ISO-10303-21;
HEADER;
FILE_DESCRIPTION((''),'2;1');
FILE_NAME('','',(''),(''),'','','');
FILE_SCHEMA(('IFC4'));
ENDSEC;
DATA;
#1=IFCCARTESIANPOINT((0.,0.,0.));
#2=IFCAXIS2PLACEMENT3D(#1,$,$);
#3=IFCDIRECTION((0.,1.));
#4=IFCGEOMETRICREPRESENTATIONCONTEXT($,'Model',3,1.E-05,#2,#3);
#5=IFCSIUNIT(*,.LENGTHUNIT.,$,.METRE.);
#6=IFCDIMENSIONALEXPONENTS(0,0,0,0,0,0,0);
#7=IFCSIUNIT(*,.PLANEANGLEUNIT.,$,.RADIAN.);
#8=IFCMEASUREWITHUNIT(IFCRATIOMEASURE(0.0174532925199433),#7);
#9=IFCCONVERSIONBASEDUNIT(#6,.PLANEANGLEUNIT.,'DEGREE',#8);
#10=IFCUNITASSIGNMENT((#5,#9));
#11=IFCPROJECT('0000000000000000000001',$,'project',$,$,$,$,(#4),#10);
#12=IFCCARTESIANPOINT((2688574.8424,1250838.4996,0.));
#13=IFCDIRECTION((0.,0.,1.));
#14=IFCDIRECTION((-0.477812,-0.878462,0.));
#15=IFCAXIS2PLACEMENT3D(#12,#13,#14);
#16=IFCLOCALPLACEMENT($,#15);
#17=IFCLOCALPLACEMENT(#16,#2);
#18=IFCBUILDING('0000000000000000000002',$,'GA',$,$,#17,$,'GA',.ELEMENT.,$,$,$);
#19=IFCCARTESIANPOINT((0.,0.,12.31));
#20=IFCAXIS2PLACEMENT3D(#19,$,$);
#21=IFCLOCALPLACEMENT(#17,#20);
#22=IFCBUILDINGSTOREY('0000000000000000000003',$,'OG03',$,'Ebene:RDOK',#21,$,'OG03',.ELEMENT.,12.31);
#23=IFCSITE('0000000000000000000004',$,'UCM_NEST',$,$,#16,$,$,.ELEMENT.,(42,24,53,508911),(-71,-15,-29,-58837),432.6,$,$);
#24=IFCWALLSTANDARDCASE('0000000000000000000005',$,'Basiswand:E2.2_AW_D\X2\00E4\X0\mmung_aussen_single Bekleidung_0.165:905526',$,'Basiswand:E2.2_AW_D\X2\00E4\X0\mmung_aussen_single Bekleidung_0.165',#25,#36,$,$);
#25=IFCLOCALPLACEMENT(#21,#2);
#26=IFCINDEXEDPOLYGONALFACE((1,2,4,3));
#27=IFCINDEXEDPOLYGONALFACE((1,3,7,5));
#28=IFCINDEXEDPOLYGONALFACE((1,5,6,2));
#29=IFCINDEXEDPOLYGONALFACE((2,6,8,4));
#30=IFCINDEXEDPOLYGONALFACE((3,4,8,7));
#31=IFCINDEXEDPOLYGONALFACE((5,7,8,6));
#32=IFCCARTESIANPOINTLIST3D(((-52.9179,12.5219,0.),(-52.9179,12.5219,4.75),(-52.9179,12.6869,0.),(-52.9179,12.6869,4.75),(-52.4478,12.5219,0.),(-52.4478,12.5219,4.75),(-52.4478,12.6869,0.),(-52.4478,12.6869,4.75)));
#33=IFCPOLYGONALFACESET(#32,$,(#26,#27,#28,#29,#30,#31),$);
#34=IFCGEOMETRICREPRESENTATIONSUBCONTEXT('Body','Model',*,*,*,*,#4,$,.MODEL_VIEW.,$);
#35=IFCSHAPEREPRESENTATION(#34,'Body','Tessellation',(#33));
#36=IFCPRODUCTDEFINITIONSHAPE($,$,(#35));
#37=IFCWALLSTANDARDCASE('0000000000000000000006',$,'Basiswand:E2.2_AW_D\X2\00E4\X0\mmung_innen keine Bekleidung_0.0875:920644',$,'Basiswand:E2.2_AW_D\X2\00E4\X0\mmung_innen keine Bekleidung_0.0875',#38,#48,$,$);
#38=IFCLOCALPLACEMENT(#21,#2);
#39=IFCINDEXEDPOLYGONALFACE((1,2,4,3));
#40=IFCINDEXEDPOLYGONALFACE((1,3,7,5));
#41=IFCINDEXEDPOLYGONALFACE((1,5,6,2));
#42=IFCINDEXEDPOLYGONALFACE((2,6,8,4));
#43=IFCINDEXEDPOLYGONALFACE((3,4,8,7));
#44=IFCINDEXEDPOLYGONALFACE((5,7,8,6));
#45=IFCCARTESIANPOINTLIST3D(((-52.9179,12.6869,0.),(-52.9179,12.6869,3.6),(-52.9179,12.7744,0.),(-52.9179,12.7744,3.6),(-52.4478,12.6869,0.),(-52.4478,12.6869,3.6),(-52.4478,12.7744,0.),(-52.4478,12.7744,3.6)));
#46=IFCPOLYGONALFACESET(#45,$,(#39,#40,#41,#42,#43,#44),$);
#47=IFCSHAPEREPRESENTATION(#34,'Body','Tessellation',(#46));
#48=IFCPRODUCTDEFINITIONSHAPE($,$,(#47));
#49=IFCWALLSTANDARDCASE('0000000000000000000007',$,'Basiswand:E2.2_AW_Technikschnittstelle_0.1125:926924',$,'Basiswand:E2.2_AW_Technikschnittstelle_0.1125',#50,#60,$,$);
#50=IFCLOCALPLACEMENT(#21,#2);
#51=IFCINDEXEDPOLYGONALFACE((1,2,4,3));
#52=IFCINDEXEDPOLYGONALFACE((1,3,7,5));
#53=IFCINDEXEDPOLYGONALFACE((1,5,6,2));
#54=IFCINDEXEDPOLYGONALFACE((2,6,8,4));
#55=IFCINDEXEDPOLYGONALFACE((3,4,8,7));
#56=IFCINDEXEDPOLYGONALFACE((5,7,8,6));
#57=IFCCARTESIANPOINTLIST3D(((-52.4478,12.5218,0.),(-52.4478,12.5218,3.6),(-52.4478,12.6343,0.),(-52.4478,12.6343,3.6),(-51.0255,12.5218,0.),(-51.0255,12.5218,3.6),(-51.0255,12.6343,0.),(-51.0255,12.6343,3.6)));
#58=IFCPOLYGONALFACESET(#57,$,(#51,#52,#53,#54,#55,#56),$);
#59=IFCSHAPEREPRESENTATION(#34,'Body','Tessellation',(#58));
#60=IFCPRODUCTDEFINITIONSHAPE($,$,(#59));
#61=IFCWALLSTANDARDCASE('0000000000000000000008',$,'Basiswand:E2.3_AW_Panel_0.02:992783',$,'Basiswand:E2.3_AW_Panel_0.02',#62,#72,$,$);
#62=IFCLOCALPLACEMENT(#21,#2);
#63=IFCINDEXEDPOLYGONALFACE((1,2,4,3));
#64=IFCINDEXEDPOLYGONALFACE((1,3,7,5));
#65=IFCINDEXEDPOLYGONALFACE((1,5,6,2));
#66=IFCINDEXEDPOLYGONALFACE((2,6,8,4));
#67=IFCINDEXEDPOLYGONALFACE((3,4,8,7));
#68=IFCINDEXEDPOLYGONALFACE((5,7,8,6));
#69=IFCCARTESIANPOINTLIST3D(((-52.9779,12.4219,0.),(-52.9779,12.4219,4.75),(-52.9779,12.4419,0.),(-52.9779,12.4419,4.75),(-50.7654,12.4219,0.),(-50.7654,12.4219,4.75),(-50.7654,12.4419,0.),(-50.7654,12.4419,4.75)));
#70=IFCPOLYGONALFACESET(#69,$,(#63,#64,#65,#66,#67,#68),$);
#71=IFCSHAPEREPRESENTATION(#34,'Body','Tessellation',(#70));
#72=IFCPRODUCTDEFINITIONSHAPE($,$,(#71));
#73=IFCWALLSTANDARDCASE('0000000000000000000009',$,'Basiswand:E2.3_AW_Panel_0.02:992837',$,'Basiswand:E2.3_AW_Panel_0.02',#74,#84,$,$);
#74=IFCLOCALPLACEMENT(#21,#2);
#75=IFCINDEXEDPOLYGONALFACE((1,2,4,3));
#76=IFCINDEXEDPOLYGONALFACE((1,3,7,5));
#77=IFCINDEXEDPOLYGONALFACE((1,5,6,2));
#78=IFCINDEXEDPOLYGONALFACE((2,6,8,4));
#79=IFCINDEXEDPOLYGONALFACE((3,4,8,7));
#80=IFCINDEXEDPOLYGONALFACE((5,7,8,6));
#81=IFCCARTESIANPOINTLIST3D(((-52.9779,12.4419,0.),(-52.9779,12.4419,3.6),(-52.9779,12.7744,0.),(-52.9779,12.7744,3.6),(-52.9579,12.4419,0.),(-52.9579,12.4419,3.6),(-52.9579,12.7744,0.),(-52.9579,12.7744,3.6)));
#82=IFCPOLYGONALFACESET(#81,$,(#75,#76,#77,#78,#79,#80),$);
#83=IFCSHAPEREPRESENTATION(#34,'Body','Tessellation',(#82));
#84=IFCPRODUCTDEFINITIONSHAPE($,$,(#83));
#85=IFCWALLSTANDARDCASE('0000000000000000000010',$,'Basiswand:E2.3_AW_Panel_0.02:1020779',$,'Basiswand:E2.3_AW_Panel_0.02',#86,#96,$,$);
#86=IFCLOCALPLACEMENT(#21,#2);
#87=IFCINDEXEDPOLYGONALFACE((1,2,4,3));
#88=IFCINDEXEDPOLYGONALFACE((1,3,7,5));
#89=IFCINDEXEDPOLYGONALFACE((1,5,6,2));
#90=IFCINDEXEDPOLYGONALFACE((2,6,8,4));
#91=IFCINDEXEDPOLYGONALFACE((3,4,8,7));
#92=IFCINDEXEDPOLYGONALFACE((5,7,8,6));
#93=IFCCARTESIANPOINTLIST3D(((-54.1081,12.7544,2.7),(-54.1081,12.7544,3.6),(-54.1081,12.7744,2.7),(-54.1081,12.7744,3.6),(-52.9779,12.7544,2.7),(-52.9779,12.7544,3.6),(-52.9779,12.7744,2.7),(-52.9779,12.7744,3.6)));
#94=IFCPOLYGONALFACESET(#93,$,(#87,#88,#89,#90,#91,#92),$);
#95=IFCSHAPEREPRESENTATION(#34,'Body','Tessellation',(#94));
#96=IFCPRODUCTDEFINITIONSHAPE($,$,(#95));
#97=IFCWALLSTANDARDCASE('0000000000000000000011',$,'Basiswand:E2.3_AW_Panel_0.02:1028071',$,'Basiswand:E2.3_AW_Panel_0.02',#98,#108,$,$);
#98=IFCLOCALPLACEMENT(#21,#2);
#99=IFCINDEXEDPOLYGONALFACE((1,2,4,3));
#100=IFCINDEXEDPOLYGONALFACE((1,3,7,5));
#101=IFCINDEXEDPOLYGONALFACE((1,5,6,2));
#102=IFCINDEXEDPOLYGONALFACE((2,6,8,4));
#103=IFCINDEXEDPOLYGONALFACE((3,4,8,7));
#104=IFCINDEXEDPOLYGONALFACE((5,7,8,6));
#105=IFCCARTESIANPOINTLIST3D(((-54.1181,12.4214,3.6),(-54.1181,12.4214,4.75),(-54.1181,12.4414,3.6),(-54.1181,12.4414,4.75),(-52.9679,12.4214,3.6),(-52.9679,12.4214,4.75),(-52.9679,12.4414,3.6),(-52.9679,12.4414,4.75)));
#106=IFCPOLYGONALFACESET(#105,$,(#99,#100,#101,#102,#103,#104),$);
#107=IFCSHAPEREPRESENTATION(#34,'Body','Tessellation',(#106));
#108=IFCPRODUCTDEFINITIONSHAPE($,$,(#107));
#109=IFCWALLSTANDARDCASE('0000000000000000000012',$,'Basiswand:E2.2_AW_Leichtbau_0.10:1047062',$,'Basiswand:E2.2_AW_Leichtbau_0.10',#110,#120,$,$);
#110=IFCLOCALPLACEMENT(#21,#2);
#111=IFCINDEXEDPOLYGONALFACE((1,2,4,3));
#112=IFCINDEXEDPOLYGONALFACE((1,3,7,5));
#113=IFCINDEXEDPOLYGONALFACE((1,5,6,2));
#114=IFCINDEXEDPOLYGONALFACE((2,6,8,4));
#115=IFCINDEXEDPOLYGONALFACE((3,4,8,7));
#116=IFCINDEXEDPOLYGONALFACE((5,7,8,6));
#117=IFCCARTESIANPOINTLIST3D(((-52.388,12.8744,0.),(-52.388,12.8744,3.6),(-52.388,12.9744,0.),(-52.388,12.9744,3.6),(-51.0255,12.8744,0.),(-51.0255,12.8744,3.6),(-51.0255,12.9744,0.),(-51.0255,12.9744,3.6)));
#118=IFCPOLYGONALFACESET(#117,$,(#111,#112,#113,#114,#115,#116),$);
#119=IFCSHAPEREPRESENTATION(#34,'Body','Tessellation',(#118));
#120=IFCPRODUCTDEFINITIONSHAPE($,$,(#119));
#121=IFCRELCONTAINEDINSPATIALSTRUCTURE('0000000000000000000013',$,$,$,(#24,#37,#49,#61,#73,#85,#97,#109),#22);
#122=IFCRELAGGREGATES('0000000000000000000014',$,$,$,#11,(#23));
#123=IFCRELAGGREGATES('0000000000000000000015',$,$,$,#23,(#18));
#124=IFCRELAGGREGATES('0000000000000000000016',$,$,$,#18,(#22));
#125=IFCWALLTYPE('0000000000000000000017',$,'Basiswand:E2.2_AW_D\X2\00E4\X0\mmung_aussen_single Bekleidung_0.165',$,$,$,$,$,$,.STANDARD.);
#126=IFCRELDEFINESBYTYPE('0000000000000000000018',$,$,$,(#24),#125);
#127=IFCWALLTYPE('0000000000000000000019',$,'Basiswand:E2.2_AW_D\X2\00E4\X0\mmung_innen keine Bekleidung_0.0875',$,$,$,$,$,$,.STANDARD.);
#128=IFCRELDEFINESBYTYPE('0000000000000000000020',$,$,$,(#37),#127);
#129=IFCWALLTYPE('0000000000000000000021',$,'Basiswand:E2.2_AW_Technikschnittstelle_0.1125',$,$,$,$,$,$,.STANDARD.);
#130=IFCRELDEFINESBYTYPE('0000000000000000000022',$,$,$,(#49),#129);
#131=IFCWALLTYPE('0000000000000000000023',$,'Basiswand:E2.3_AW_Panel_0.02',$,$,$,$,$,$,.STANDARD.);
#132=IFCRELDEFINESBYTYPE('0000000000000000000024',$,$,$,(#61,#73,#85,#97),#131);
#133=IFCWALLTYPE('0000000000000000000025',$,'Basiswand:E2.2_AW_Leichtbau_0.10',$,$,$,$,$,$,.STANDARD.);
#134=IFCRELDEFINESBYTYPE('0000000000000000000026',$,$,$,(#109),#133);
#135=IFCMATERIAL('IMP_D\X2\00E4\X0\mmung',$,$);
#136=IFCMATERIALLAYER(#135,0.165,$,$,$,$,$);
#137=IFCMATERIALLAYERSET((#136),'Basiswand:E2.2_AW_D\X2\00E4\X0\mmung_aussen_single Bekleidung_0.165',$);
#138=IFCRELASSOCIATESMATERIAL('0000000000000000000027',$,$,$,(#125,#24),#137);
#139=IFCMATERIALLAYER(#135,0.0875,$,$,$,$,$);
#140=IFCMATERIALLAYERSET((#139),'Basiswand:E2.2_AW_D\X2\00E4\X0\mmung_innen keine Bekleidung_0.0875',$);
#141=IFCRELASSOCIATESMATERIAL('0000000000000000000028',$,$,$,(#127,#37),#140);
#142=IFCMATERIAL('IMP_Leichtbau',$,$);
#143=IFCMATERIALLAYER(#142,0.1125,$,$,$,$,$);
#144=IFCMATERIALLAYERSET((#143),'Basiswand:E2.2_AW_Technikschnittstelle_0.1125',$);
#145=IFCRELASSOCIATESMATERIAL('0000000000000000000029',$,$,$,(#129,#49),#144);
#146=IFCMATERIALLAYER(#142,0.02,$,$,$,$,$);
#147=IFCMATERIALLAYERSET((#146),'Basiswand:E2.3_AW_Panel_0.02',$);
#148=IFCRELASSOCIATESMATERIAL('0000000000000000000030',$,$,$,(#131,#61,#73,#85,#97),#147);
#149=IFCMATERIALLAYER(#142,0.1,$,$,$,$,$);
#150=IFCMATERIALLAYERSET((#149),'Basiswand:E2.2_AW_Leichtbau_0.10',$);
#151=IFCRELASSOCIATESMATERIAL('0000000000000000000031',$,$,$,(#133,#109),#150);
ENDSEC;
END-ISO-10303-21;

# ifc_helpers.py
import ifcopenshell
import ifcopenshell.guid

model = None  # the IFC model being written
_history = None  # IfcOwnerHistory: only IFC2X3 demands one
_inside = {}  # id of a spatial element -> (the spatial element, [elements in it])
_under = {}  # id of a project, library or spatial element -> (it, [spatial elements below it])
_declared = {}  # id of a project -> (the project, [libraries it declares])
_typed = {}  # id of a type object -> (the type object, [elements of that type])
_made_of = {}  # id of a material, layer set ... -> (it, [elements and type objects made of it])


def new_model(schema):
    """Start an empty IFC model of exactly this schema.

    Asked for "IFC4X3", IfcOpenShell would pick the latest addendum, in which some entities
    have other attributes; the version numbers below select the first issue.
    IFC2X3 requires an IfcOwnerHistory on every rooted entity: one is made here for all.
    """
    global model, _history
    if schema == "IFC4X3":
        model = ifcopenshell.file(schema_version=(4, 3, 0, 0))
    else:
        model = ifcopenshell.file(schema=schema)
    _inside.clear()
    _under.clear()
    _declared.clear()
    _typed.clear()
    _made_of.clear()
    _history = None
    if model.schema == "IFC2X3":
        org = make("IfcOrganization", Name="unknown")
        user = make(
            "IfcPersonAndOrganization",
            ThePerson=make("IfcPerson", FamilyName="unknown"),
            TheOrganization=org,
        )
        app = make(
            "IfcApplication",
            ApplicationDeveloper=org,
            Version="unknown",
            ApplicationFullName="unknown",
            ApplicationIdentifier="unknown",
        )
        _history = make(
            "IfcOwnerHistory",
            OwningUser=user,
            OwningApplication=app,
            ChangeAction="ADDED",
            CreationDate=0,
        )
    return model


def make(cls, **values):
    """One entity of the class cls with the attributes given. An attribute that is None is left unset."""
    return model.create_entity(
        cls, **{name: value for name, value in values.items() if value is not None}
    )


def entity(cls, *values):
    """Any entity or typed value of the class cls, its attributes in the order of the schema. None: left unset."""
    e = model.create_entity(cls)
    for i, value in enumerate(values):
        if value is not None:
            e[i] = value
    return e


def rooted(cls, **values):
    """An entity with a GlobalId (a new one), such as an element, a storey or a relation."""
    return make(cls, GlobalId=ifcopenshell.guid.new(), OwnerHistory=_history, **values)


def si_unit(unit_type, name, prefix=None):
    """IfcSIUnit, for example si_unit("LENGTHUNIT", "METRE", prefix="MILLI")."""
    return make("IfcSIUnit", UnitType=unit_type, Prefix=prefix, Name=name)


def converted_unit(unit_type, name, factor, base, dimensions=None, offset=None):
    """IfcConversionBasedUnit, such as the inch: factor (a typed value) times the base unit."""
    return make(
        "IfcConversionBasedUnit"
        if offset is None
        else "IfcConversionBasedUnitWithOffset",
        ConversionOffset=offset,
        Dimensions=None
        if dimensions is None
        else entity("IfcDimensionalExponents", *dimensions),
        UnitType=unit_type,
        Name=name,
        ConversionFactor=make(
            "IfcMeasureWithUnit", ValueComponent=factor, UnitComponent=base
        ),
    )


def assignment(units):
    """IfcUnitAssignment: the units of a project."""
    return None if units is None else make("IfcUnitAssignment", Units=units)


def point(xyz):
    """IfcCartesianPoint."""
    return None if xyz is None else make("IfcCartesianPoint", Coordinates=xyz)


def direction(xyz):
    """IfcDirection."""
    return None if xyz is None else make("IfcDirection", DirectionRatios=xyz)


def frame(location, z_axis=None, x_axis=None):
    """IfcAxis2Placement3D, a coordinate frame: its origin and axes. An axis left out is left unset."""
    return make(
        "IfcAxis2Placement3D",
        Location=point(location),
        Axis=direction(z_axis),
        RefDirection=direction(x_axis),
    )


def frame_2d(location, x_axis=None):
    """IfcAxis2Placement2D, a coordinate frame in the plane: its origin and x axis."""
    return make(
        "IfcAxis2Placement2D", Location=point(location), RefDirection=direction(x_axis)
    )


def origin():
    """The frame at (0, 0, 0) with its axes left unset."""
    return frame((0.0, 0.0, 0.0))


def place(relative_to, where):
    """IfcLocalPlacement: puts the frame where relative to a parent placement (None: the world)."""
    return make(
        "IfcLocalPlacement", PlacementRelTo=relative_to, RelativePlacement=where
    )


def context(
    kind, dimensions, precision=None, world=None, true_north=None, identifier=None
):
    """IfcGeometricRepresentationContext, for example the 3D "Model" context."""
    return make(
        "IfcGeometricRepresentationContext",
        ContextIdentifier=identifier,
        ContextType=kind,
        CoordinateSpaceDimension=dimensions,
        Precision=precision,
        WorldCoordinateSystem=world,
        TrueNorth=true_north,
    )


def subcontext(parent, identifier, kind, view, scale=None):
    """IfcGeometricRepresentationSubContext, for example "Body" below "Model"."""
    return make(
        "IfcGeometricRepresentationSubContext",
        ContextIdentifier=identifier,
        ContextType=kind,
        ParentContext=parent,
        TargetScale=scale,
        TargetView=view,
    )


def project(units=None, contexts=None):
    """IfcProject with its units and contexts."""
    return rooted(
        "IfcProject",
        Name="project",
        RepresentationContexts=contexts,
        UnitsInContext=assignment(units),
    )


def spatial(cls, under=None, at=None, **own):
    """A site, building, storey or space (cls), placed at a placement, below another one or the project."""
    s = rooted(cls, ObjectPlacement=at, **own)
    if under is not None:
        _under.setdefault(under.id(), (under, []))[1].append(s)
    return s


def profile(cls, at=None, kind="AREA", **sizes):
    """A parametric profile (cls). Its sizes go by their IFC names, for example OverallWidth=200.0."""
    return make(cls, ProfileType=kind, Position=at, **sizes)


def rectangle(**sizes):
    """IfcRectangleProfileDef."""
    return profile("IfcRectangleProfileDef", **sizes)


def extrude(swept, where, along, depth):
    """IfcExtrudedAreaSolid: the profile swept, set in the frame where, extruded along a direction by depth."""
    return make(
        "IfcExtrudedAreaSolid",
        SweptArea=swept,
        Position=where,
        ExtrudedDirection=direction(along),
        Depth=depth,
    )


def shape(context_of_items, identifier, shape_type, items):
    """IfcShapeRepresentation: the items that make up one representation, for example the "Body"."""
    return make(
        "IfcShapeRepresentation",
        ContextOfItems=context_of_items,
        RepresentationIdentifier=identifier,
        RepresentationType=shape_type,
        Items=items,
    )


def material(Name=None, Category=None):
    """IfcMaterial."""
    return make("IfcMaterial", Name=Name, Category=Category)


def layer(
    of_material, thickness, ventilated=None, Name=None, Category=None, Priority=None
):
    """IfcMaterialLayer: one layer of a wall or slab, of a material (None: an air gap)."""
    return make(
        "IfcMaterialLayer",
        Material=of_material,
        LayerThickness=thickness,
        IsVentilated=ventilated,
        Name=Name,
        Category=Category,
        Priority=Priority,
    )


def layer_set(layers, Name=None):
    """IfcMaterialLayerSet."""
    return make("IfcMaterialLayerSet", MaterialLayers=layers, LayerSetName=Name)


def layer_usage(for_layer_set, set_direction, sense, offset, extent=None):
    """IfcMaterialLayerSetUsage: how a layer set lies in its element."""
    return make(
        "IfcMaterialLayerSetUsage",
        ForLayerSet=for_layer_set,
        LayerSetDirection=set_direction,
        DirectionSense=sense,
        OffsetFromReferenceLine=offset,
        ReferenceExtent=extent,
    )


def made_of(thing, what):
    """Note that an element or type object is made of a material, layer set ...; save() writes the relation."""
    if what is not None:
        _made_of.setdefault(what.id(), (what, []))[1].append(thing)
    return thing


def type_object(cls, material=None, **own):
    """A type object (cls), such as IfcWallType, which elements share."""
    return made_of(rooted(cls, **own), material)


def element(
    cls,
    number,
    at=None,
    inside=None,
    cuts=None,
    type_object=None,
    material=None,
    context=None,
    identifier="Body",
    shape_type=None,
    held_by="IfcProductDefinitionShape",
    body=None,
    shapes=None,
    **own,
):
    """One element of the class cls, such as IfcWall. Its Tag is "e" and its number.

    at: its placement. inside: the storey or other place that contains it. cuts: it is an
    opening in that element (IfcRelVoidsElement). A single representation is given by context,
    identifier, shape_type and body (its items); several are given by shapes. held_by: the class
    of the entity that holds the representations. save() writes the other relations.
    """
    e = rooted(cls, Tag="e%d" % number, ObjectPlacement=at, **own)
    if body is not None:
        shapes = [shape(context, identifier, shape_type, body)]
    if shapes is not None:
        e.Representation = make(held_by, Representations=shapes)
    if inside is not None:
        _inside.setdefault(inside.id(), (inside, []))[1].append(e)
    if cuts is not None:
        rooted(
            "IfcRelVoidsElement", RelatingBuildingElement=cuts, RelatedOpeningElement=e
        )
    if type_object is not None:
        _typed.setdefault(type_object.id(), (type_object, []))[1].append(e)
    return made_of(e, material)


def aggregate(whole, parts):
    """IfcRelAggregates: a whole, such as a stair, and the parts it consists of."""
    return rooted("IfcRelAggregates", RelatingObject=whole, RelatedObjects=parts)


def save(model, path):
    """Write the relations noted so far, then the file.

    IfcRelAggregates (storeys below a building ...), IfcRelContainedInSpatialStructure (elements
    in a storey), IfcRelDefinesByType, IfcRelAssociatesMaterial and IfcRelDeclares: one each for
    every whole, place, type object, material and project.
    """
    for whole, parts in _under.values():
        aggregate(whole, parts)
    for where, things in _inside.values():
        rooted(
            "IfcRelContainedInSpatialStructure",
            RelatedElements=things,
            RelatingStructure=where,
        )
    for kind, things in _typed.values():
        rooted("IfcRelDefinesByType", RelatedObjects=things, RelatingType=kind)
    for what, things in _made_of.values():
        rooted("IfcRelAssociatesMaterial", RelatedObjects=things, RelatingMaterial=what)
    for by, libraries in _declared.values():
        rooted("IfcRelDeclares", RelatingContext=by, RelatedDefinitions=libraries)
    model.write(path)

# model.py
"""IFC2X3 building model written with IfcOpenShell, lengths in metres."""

from ifc_helpers import new_model, entity, si_unit, converted_unit, direction, frame, frame_2d, origin, place, context, subcontext, project, spatial, rectangle, extrude, material, layer, layer_set, layer_usage, type_object, element, save


model = new_model("IFC2X3")

# Units and contexts
model_context = context("Model", 3, precision=1e-05, world=origin(), true_north=direction((0.0, 1.0)))
body_context = subcontext(model_context, "Body", "Model", "MODEL_VIEW")
ifc_project = project(units=[si_unit("LENGTHUNIT", "METRE"), converted_unit("PLANEANGLEUNIT", "DEGREE", entity("IfcRatioMeasure", 0.0174532925199433), si_unit("PLANEANGLEUNIT", "RADIAN"), dimensions=[0, 0, 0, 0, 0, 0, 0])], contexts=[model_context])

# Site, building, storey
site_placement = place(None, frame((2688574.8424, 1250838.4996, 0.0), z_axis=(0.0, 0.0, 1.0), x_axis=(-0.477812, -0.878462, 0.0)))
site = spatial("IfcSite", under=ifc_project, at=site_placement, Name="UCM_NEST", CompositionType="ELEMENT", RefLatitude=(42, 24, 53, 508911), RefLongitude=(-71, -15, -29, -58837), RefElevation=432.6)
building_placement = place(site_placement, origin())
building = spatial("IfcBuilding", under=site, at=building_placement, Name="GA", LongName="GA", CompositionType="ELEMENT")
storey_placement = place(building_placement, frame((0.0, 0.0, 12.31)))
storey = spatial("IfcBuildingStorey", under=building, at=storey_placement, Name="OG03", ObjectType="Ebene:RDOK", LongName="OG03", CompositionType="ELEMENT", Elevation=12.31)

# Shared definitions
ifc_material_1 = material(Name="IMP_Dämmung")

# Wall
ifc_layer_1 = layer(ifc_material_1, 0.165)
ifc_layer_set_1 = layer_set([ifc_layer_1], Name="Basiswand:E2.2_AW_Dämmung_aussen_single Bekleidung_0.165")
ifc_layer_usage_1 = layer_usage(ifc_layer_set_1, "AXIS2", "NEGATIVE", 0.0825)
wall_type_1 = type_object("IfcWallType", Name="Basiswand:E2.2_AW_Dämmung_aussen_single Bekleidung_0.165", PredefinedType="STANDARD", material=ifc_layer_set_1)
wall_1_placement = place(storey_placement, frame((-52.4478, 12.6044, 0.0), z_axis=(0.0, 0.0, 1.0), x_axis=(-1.0, 0.0, 0.0)))
element("IfcWallStandardCase", 1, at=wall_1_placement, inside=storey, type_object=wall_type_1, material=ifc_layer_usage_1, Name="Basiswand:E2.2_AW_Dämmung_aussen_single Bekleidung_0.165:905526", ObjectType="Basiswand:E2.2_AW_Dämmung_aussen_single Bekleidung_0.165", context=body_context, shape_type="SweptSolid", body=[
    extrude(rectangle(XDim=0.4701, YDim=0.165, at=frame_2d((0.235, 0.0), x_axis=(-1.0, 0.0))), origin(), (0.0, 0.0, 1.0), 4.75),
])

# Walls
ifc_layer_2 = layer(ifc_material_1, 0.0875)
ifc_layer_set_2 = layer_set([ifc_layer_2], Name="Basiswand:E2.2_AW_Dämmung_innen keine Bekleidung_0.0875")
ifc_layer_usage_2 = layer_usage(ifc_layer_set_2, "AXIS2", "NEGATIVE", 0.0437)
wall_type_2 = type_object("IfcWallType", Name="Basiswand:E2.2_AW_Dämmung_innen keine Bekleidung_0.0875", PredefinedType="STANDARD", material=ifc_layer_set_2)
wall_2_placement = place(storey_placement, frame((-52.4478, 12.7307, 0.0), z_axis=(0.0, 0.0, 1.0), x_axis=(-1.0, 0.0, 0.0)))
element("IfcWallStandardCase", 2, at=wall_2_placement, inside=storey, type_object=wall_type_2, material=ifc_layer_usage_2, Name="Basiswand:E2.2_AW_Dämmung_innen keine Bekleidung_0.0875:920644", ObjectType="Basiswand:E2.2_AW_Dämmung_innen keine Bekleidung_0.0875", context=body_context, shape_type="SweptSolid", body=[
    extrude(rectangle(XDim=0.4701, YDim=0.0875, at=frame_2d((0.235, 0.0), x_axis=(-1.0, 0.0))), origin(), (0.0, 0.0, 1.0), 3.6),
])
ifc_material_2 = material(Name="IMP_Leichtbau")
ifc_layer_3 = layer(ifc_material_2, 0.1125)
ifc_layer_set_3 = layer_set([ifc_layer_3], Name="Basiswand:E2.2_AW_Technikschnittstelle_0.1125")
ifc_layer_usage_3 = layer_usage(ifc_layer_set_3, "AXIS2", "NEGATIVE", 0.0563)
wall_type_3 = type_object("IfcWallType", Name="Basiswand:E2.2_AW_Technikschnittstelle_0.1125", PredefinedType="STANDARD", material=ifc_layer_set_3)
wall_3_placement = place(storey_placement, frame((-52.4478, 12.578, 0.0)))
element("IfcWallStandardCase", 3, at=wall_3_placement, inside=storey, type_object=wall_type_3, material=ifc_layer_usage_3, Name="Basiswand:E2.2_AW_Technikschnittstelle_0.1125:926924", ObjectType="Basiswand:E2.2_AW_Technikschnittstelle_0.1125", context=body_context, shape_type="SweptSolid", body=[
    extrude(rectangle(XDim=1.4223, YDim=0.1125, at=frame_2d((0.7112, 0.0), x_axis=(-1.0, 0.0))), origin(), (0.0, 0.0, 1.0), 3.6),
])
ifc_layer_4 = layer(ifc_material_2, 0.02)
ifc_layer_set_4 = layer_set([ifc_layer_4], Name="Basiswand:E2.3_AW_Panel_0.02")
ifc_layer_usage_4 = layer_usage(ifc_layer_set_4, "AXIS2", "NEGATIVE", 0.01)
wall_type_4 = type_object("IfcWallType", Name="Basiswand:E2.3_AW_Panel_0.02", PredefinedType="STANDARD", material=ifc_layer_set_4)
wall_4_placement = place(storey_placement, frame((-50.7654, 12.4319, 0.0), z_axis=(0.0, 0.0, 1.0), x_axis=(-1.0, 0.0, 0.0)))
element("IfcWallStandardCase", 4, at=wall_4_placement, inside=storey, type_object=wall_type_4, material=ifc_layer_usage_4, Name="Basiswand:E2.3_AW_Panel_0.02:992783", ObjectType="Basiswand:E2.3_AW_Panel_0.02", context=body_context, shape_type="SweptSolid", body=[
    extrude(rectangle(XDim=2.2124, YDim=0.02, at=frame_2d((1.1062, 0.0), x_axis=(-1.0, 0.0))), origin(), (0.0, 0.0, 1.0), 4.75),
])
ifc_layer_usage_5 = layer_usage(ifc_layer_set_4, "AXIS2", "NEGATIVE", 0.01)
wall_5_placement = place(storey_placement, frame((-52.9679, 12.7744, 0.0), z_axis=(0.0, 0.0, 1.0), x_axis=(0.0, -1.0, 0.0)))
element("IfcWallStandardCase", 5, at=wall_5_placement, inside=storey, type_object=wall_type_4, material=ifc_layer_usage_5, Name="Basiswand:E2.3_AW_Panel_0.02:992837", ObjectType="Basiswand:E2.3_AW_Panel_0.02", context=body_context, shape_type="SweptSolid", body=[
    extrude(rectangle(XDim=0.3325, YDim=0.02, at=frame_2d((0.1663, 0.0), x_axis=(-1.0, 0.0))), origin(), (0.0, 0.0, 1.0), 3.6),
])
ifc_layer_usage_6 = layer_usage(ifc_layer_set_4, "AXIS2", "NEGATIVE", 0.01)
wall_6_placement = place(storey_placement, frame((-52.9779, 12.7644, 2.7), z_axis=(0.0, 0.0, 1.0), x_axis=(-1.0, 0.0, 0.0)))
element("IfcWallStandardCase", 6, at=wall_6_placement, inside=storey, type_object=wall_type_4, material=ifc_layer_usage_6, Name="Basiswand:E2.3_AW_Panel_0.02:1020779", ObjectType="Basiswand:E2.3_AW_Panel_0.02", context=body_context, shape_type="SweptSolid", body=[
    extrude(rectangle(XDim=1.1302, YDim=0.02, at=frame_2d((0.5651, 0.0), x_axis=(-1.0, 0.0))), origin(), (0.0, 0.0, 1.0), 0.9),
])
ifc_layer_usage_7 = layer_usage(ifc_layer_set_4, "AXIS2", "NEGATIVE", 0.01)
wall_7_placement = place(storey_placement, frame((-54.1181, 12.4314, 3.6)))
element("IfcWallStandardCase", 7, at=wall_7_placement, inside=storey, type_object=wall_type_4, material=ifc_layer_usage_7, Name="Basiswand:E2.3_AW_Panel_0.02:1028071", ObjectType="Basiswand:E2.3_AW_Panel_0.02", context=body_context, shape_type="SweptSolid", body=[
    extrude(rectangle(XDim=1.1502, YDim=0.02, at=frame_2d((0.5751, 0.0), x_axis=(-1.0, 0.0))), origin(), (0.0, 0.0, 1.0), 1.15),
])
ifc_layer_5 = layer(ifc_material_2, 0.1)
ifc_layer_set_5 = layer_set([ifc_layer_5], Name="Basiswand:E2.2_AW_Leichtbau_0.10")
ifc_layer_usage_8 = layer_usage(ifc_layer_set_5, "AXIS2", "NEGATIVE", 0.05)
wall_type_5 = type_object("IfcWallType", Name="Basiswand:E2.2_AW_Leichtbau_0.10", PredefinedType="STANDARD", material=ifc_layer_set_5)
wall_8_placement = place(storey_placement, frame((-52.388, 12.9244, 0.0)))
element("IfcWallStandardCase", 8, at=wall_8_placement, inside=storey, type_object=wall_type_5, material=ifc_layer_usage_8, Name="Basiswand:E2.2_AW_Leichtbau_0.10:1047062", ObjectType="Basiswand:E2.2_AW_Leichtbau_0.10", context=body_context, shape_type="SweptSolid", body=[
    extrude(rectangle(XDim=1.3625, YDim=0.1, at=frame_2d((0.6812, 0.0), x_axis=(-1.0, 0.0))), origin(), (0.0, 0.0, 1.0), 3.6),
])

save(model, "model.ifc")
